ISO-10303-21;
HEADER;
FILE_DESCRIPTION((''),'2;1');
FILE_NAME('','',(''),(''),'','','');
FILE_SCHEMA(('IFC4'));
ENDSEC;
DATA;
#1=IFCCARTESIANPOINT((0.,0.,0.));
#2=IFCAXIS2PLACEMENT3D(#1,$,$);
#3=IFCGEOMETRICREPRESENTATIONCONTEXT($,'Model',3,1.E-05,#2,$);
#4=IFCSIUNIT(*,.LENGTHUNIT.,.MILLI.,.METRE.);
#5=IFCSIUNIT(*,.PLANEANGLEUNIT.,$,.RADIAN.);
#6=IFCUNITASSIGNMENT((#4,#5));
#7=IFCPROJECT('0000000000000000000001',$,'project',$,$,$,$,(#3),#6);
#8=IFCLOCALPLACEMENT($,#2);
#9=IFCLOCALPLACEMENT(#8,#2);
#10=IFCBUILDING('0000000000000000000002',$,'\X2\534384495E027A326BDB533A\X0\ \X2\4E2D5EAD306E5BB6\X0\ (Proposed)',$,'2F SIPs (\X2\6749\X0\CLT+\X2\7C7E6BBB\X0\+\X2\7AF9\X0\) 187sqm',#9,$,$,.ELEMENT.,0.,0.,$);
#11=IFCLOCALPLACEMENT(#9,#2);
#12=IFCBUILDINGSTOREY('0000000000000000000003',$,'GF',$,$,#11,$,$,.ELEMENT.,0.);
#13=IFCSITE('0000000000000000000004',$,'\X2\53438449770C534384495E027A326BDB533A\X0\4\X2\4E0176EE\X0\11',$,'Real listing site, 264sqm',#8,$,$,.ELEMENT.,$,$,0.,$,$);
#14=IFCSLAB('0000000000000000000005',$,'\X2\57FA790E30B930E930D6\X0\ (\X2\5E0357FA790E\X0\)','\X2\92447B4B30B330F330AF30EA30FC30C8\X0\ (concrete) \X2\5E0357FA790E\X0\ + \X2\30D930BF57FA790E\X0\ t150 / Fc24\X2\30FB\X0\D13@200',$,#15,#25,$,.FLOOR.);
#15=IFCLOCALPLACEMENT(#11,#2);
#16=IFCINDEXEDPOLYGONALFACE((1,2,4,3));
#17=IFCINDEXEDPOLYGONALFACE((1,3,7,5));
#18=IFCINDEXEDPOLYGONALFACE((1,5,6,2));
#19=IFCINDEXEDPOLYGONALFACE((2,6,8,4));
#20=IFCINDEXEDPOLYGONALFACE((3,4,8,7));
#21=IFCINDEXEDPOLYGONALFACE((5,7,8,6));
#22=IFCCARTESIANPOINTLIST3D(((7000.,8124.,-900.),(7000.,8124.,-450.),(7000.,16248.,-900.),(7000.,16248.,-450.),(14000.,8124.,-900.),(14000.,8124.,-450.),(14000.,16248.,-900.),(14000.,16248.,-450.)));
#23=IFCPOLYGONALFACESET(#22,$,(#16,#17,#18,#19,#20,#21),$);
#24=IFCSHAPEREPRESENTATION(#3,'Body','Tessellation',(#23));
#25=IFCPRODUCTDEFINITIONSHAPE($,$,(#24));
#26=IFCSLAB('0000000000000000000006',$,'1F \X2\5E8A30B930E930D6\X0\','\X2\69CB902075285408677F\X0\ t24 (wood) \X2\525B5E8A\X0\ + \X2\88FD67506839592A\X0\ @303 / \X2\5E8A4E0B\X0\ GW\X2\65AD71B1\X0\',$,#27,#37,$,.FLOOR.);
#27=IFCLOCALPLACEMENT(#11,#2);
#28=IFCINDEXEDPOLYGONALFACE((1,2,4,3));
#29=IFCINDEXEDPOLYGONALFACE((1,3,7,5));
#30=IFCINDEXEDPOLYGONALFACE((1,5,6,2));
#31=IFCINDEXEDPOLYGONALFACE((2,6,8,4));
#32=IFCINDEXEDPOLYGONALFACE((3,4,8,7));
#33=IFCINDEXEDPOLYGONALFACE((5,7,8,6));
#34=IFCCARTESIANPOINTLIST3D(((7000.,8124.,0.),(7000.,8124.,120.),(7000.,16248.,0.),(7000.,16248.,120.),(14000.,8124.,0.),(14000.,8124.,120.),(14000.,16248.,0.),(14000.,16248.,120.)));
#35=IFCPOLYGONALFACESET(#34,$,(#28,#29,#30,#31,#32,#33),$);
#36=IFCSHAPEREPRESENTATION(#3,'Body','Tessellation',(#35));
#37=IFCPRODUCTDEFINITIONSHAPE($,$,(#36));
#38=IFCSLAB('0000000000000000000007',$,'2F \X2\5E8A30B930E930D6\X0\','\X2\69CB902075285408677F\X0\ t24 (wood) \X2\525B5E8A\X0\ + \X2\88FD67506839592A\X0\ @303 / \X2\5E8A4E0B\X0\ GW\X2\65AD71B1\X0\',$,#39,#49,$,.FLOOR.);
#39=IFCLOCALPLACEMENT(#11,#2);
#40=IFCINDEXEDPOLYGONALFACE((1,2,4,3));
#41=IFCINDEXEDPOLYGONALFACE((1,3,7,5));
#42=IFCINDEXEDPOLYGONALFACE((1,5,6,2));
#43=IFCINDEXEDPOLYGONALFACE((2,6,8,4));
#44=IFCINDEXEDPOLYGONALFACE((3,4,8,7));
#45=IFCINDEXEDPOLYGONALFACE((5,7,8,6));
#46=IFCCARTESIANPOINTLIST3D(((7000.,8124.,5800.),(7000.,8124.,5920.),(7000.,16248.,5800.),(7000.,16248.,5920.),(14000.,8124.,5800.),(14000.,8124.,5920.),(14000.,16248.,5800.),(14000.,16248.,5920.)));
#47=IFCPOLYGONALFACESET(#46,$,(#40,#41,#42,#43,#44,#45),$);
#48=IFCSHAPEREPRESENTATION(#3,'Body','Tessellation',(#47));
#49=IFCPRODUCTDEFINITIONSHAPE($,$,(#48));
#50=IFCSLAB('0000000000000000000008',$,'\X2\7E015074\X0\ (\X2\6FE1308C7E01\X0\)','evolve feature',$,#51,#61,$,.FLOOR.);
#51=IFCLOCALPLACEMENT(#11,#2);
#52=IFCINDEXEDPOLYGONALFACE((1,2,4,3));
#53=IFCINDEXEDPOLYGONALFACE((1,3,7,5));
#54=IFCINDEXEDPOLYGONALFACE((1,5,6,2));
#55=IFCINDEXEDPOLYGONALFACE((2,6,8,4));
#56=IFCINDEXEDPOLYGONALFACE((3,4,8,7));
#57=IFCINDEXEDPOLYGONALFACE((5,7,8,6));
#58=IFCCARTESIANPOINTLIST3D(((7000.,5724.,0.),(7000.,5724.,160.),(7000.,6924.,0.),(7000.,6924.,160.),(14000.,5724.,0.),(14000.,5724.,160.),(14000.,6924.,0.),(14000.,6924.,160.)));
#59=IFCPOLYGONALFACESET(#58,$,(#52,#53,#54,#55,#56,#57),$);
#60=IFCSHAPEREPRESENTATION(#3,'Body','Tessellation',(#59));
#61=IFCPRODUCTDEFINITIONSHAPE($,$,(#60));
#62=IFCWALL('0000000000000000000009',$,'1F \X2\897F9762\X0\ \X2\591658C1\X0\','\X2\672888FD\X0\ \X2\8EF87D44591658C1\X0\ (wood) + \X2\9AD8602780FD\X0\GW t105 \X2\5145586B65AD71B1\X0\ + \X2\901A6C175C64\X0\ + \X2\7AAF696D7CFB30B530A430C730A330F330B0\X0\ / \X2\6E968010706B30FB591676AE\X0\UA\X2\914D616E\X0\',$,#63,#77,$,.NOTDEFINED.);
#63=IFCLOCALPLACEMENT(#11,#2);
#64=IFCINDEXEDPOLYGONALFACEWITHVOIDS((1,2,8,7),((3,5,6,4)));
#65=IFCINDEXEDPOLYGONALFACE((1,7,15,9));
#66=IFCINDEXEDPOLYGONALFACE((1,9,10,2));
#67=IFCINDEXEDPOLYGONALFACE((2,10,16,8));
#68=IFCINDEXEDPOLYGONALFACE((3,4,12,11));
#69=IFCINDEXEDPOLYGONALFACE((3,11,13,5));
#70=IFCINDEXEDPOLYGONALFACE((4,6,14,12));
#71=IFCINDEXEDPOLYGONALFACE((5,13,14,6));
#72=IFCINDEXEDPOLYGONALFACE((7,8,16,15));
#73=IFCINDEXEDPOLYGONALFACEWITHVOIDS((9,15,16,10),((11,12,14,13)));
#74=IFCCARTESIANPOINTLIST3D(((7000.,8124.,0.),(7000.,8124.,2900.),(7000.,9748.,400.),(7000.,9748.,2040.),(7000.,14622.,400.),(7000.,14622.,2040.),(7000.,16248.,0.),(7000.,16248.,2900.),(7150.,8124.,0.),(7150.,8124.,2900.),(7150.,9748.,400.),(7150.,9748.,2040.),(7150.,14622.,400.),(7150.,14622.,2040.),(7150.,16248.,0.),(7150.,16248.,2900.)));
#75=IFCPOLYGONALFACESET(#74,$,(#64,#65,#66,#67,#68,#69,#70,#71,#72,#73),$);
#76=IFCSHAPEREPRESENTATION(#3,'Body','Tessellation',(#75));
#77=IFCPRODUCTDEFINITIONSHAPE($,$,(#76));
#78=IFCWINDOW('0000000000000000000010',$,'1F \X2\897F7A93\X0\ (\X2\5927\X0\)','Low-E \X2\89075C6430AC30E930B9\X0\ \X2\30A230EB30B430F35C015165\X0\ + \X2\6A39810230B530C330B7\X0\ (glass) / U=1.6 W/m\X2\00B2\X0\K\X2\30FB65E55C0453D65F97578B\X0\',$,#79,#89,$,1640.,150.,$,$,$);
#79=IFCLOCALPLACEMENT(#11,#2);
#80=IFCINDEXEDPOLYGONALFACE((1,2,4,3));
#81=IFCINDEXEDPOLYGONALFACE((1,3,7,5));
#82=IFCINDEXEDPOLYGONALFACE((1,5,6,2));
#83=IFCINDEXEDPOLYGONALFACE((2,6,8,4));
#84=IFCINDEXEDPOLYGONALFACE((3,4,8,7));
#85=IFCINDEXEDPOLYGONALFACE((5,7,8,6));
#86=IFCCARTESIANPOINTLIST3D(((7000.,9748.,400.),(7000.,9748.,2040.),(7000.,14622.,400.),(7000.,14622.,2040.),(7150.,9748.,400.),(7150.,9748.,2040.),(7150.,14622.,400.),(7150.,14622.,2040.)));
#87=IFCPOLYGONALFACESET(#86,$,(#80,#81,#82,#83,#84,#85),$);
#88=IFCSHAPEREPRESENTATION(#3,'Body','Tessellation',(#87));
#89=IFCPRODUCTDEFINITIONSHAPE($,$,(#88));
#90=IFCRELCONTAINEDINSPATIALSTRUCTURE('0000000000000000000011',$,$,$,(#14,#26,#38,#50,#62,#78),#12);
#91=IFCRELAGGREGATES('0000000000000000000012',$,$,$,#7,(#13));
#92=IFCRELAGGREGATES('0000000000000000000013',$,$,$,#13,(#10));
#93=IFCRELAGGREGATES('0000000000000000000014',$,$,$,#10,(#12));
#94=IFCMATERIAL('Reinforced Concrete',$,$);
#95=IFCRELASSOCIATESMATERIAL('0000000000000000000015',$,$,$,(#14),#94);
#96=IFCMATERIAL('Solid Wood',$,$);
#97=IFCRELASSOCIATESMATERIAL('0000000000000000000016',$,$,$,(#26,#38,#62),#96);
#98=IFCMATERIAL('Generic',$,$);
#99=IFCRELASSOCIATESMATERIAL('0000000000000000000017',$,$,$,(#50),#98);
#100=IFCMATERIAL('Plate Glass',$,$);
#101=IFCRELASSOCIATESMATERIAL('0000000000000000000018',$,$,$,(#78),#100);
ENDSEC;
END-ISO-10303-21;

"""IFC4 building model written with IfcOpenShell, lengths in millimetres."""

from ifc_helpers import new_model, si_unit, frame, frame_2d, origin, place, context, project, spatial, rectangle, extrude, material, element, fill, save


model = new_model("IFC4")

# Units and contexts
model_context = context("Model", 3, precision=1e-05, world=origin())
ifc_project = project(units=[si_unit("LENGTHUNIT", "METRE", prefix="MILLI"), si_unit("PLANEANGLEUNIT", "RADIAN")], contexts=[model_context])

# Site, building, storey
site_placement = place(None, origin())
site = spatial("IfcSite", under=ifc_project, at=site_placement, Name="千葉県千葉市稲毛区4丁目11", ObjectType="Real listing site, 264sqm", CompositionType="ELEMENT", RefElevation=0.0)
building_placement = place(site_placement, origin())
building = spatial("IfcBuilding", under=site, at=building_placement, Name="千葉市稲毛区 中庭の家 (Proposed)", ObjectType="2F SIPs (杉CLT+籾殻+竹) 187sqm", CompositionType="ELEMENT", ElevationOfRefHeight=0.0, ElevationOfTerrain=0.0)
storey_placement = place(building_placement, origin())
storey = spatial("IfcBuildingStorey", under=building, at=storey_placement, Name="GF", CompositionType="ELEMENT", Elevation=0.0)

# Slabs
ifc_material_1 = material(Name="Reinforced Concrete")
slab_1_placement = place(storey_placement, frame((3500.0, 4062.0, -450.0)))
element("IfcSlab", 1, at=slab_1_placement, inside=storey, material=ifc_material_1, Name="基礎スラブ (布基礎)", Description="鉄筋コンクリート (concrete) 布基礎 + ベタ基礎 t150 / Fc24・D13@200", PredefinedType="FLOOR", context=model_context, shape_type="SweptSolid", body=[
    extrude(rectangle(XDim=7000.0, YDim=8124.0, at=frame_2d((3500.0, 4062.0))), frame((3500.0, 4062.0, -450.0)), (0.0, 0.0, 1.0), 450.0),
])
ifc_material_2 = material(Name="Solid Wood")
slab_2_placement = place(storey_placement, frame((3500.0, 4062.0, 0.0)))
element("IfcSlab", 2, at=slab_2_placement, inside=storey, material=ifc_material_2, Name="1F 床スラブ", Description="構造用合板 t24 (wood) 剛床 + 製材根太 @303 / 床下 GW断熱", PredefinedType="FLOOR", context=model_context, shape_type="SweptSolid", body=[
    extrude(rectangle(XDim=7000.0, YDim=8124.0, at=frame_2d((3500.0, 4062.0))), frame((3500.0, 4062.0, 0.0)), (0.0, 0.0, 1.0), 120.0),
])
slab_3_placement = place(storey_placement, frame((3500.0, 4062.0, 2900.0)))
element("IfcSlab", 3, at=slab_3_placement, inside=storey, material=ifc_material_2, Name="2F 床スラブ", Description="構造用合板 t24 (wood) 剛床 + 製材根太 @303 / 床下 GW断熱", PredefinedType="FLOOR", context=model_context, shape_type="SweptSolid", body=[
    extrude(rectangle(XDim=7000.0, YDim=8124.0, at=frame_2d((3500.0, 4062.0))), frame((3500.0, 4062.0, 2900.0)), (0.0, 0.0, 1.0), 120.0),
])
ifc_material_3 = material(Name="Generic")
slab_4_placement = place(storey_placement, frame((3500.0, 2862.0, 0.0)))
element("IfcSlab", 4, at=slab_4_placement, inside=storey, material=ifc_material_3, Name="縁側 (濡れ縁)", Description="evolve feature", PredefinedType="FLOOR", context=model_context, shape_type="SweptSolid", body=[
    extrude(rectangle(XDim=7000.0, YDim=1200.0, at=frame_2d((3500.0, 600.0))), frame((3500.0, 2862.0, 0.0)), (0.0, 0.0, 1.0), 160.0),
])

# Shared definitions
ifc_material_4 = material(Name="Plate Glass")

# Wall, opening, window
wall_1_placement = place(storey_placement, frame((3500.0, 4062.0, 0.0)))
wall_1 = element("IfcWall", 5, at=wall_1_placement, inside=storey, material=ifc_material_2, Name="1F 西面 外壁", Description="木製 軸組外壁 (wood) + 高性能GW t105 充填断熱 + 通気層 + 窯業系サイディング / 準耐火・外皮UA配慮", PredefinedType="NOTDEFINED", context=model_context, shape_type="SweptSolid", body=[
    extrude(rectangle(XDim=150.0, YDim=8124.0, at=frame_2d((75.0, 4062.0))), frame((3500.0, 4062.0, 0.0)), (0.0, 0.0, 1.0), 2900.0),
])
opening_1_placement = place(storey_placement, frame((3500.0, 4874.0, 200.0)))
opening_1 = element("IfcOpeningElement", 6, at=opening_1_placement, cuts=wall_1, PredefinedType="NOTDEFINED", context=model_context, shape_type="SweptSolid", body=[
    extrude(rectangle(XDim=150.0, YDim=4874.0, at=frame_2d((75.0, 2437.0))), frame((3500.0, 4874.0, 200.0)), (0.0, 0.0, 1.0), 1640.0),
])
window_1_placement = place(storey_placement, frame((3500.0, 4874.0, 200.0)))
window_1 = element("IfcWindow", 7, at=window_1_placement, inside=storey, material=ifc_material_4, Name="1F 西窓 (大)", Description="Low-E 複層ガラス アルゴン封入 + 樹脂サッシ (glass) / U=1.6 W/m²K・日射取得型", OverallHeight=1640.0, OverallWidth=150.0, context=model_context, shape_type="SweptSolid", body=[
    extrude(rectangle(XDim=150.0, YDim=4874.0, at=frame_2d((75.0, 2437.0))), frame((3500.0, 4874.0, 200.0)), (0.0, 0.0, 1.0), 1640.0),
])
fill(opening_1, window_1)

save(model, "model.ifc")
